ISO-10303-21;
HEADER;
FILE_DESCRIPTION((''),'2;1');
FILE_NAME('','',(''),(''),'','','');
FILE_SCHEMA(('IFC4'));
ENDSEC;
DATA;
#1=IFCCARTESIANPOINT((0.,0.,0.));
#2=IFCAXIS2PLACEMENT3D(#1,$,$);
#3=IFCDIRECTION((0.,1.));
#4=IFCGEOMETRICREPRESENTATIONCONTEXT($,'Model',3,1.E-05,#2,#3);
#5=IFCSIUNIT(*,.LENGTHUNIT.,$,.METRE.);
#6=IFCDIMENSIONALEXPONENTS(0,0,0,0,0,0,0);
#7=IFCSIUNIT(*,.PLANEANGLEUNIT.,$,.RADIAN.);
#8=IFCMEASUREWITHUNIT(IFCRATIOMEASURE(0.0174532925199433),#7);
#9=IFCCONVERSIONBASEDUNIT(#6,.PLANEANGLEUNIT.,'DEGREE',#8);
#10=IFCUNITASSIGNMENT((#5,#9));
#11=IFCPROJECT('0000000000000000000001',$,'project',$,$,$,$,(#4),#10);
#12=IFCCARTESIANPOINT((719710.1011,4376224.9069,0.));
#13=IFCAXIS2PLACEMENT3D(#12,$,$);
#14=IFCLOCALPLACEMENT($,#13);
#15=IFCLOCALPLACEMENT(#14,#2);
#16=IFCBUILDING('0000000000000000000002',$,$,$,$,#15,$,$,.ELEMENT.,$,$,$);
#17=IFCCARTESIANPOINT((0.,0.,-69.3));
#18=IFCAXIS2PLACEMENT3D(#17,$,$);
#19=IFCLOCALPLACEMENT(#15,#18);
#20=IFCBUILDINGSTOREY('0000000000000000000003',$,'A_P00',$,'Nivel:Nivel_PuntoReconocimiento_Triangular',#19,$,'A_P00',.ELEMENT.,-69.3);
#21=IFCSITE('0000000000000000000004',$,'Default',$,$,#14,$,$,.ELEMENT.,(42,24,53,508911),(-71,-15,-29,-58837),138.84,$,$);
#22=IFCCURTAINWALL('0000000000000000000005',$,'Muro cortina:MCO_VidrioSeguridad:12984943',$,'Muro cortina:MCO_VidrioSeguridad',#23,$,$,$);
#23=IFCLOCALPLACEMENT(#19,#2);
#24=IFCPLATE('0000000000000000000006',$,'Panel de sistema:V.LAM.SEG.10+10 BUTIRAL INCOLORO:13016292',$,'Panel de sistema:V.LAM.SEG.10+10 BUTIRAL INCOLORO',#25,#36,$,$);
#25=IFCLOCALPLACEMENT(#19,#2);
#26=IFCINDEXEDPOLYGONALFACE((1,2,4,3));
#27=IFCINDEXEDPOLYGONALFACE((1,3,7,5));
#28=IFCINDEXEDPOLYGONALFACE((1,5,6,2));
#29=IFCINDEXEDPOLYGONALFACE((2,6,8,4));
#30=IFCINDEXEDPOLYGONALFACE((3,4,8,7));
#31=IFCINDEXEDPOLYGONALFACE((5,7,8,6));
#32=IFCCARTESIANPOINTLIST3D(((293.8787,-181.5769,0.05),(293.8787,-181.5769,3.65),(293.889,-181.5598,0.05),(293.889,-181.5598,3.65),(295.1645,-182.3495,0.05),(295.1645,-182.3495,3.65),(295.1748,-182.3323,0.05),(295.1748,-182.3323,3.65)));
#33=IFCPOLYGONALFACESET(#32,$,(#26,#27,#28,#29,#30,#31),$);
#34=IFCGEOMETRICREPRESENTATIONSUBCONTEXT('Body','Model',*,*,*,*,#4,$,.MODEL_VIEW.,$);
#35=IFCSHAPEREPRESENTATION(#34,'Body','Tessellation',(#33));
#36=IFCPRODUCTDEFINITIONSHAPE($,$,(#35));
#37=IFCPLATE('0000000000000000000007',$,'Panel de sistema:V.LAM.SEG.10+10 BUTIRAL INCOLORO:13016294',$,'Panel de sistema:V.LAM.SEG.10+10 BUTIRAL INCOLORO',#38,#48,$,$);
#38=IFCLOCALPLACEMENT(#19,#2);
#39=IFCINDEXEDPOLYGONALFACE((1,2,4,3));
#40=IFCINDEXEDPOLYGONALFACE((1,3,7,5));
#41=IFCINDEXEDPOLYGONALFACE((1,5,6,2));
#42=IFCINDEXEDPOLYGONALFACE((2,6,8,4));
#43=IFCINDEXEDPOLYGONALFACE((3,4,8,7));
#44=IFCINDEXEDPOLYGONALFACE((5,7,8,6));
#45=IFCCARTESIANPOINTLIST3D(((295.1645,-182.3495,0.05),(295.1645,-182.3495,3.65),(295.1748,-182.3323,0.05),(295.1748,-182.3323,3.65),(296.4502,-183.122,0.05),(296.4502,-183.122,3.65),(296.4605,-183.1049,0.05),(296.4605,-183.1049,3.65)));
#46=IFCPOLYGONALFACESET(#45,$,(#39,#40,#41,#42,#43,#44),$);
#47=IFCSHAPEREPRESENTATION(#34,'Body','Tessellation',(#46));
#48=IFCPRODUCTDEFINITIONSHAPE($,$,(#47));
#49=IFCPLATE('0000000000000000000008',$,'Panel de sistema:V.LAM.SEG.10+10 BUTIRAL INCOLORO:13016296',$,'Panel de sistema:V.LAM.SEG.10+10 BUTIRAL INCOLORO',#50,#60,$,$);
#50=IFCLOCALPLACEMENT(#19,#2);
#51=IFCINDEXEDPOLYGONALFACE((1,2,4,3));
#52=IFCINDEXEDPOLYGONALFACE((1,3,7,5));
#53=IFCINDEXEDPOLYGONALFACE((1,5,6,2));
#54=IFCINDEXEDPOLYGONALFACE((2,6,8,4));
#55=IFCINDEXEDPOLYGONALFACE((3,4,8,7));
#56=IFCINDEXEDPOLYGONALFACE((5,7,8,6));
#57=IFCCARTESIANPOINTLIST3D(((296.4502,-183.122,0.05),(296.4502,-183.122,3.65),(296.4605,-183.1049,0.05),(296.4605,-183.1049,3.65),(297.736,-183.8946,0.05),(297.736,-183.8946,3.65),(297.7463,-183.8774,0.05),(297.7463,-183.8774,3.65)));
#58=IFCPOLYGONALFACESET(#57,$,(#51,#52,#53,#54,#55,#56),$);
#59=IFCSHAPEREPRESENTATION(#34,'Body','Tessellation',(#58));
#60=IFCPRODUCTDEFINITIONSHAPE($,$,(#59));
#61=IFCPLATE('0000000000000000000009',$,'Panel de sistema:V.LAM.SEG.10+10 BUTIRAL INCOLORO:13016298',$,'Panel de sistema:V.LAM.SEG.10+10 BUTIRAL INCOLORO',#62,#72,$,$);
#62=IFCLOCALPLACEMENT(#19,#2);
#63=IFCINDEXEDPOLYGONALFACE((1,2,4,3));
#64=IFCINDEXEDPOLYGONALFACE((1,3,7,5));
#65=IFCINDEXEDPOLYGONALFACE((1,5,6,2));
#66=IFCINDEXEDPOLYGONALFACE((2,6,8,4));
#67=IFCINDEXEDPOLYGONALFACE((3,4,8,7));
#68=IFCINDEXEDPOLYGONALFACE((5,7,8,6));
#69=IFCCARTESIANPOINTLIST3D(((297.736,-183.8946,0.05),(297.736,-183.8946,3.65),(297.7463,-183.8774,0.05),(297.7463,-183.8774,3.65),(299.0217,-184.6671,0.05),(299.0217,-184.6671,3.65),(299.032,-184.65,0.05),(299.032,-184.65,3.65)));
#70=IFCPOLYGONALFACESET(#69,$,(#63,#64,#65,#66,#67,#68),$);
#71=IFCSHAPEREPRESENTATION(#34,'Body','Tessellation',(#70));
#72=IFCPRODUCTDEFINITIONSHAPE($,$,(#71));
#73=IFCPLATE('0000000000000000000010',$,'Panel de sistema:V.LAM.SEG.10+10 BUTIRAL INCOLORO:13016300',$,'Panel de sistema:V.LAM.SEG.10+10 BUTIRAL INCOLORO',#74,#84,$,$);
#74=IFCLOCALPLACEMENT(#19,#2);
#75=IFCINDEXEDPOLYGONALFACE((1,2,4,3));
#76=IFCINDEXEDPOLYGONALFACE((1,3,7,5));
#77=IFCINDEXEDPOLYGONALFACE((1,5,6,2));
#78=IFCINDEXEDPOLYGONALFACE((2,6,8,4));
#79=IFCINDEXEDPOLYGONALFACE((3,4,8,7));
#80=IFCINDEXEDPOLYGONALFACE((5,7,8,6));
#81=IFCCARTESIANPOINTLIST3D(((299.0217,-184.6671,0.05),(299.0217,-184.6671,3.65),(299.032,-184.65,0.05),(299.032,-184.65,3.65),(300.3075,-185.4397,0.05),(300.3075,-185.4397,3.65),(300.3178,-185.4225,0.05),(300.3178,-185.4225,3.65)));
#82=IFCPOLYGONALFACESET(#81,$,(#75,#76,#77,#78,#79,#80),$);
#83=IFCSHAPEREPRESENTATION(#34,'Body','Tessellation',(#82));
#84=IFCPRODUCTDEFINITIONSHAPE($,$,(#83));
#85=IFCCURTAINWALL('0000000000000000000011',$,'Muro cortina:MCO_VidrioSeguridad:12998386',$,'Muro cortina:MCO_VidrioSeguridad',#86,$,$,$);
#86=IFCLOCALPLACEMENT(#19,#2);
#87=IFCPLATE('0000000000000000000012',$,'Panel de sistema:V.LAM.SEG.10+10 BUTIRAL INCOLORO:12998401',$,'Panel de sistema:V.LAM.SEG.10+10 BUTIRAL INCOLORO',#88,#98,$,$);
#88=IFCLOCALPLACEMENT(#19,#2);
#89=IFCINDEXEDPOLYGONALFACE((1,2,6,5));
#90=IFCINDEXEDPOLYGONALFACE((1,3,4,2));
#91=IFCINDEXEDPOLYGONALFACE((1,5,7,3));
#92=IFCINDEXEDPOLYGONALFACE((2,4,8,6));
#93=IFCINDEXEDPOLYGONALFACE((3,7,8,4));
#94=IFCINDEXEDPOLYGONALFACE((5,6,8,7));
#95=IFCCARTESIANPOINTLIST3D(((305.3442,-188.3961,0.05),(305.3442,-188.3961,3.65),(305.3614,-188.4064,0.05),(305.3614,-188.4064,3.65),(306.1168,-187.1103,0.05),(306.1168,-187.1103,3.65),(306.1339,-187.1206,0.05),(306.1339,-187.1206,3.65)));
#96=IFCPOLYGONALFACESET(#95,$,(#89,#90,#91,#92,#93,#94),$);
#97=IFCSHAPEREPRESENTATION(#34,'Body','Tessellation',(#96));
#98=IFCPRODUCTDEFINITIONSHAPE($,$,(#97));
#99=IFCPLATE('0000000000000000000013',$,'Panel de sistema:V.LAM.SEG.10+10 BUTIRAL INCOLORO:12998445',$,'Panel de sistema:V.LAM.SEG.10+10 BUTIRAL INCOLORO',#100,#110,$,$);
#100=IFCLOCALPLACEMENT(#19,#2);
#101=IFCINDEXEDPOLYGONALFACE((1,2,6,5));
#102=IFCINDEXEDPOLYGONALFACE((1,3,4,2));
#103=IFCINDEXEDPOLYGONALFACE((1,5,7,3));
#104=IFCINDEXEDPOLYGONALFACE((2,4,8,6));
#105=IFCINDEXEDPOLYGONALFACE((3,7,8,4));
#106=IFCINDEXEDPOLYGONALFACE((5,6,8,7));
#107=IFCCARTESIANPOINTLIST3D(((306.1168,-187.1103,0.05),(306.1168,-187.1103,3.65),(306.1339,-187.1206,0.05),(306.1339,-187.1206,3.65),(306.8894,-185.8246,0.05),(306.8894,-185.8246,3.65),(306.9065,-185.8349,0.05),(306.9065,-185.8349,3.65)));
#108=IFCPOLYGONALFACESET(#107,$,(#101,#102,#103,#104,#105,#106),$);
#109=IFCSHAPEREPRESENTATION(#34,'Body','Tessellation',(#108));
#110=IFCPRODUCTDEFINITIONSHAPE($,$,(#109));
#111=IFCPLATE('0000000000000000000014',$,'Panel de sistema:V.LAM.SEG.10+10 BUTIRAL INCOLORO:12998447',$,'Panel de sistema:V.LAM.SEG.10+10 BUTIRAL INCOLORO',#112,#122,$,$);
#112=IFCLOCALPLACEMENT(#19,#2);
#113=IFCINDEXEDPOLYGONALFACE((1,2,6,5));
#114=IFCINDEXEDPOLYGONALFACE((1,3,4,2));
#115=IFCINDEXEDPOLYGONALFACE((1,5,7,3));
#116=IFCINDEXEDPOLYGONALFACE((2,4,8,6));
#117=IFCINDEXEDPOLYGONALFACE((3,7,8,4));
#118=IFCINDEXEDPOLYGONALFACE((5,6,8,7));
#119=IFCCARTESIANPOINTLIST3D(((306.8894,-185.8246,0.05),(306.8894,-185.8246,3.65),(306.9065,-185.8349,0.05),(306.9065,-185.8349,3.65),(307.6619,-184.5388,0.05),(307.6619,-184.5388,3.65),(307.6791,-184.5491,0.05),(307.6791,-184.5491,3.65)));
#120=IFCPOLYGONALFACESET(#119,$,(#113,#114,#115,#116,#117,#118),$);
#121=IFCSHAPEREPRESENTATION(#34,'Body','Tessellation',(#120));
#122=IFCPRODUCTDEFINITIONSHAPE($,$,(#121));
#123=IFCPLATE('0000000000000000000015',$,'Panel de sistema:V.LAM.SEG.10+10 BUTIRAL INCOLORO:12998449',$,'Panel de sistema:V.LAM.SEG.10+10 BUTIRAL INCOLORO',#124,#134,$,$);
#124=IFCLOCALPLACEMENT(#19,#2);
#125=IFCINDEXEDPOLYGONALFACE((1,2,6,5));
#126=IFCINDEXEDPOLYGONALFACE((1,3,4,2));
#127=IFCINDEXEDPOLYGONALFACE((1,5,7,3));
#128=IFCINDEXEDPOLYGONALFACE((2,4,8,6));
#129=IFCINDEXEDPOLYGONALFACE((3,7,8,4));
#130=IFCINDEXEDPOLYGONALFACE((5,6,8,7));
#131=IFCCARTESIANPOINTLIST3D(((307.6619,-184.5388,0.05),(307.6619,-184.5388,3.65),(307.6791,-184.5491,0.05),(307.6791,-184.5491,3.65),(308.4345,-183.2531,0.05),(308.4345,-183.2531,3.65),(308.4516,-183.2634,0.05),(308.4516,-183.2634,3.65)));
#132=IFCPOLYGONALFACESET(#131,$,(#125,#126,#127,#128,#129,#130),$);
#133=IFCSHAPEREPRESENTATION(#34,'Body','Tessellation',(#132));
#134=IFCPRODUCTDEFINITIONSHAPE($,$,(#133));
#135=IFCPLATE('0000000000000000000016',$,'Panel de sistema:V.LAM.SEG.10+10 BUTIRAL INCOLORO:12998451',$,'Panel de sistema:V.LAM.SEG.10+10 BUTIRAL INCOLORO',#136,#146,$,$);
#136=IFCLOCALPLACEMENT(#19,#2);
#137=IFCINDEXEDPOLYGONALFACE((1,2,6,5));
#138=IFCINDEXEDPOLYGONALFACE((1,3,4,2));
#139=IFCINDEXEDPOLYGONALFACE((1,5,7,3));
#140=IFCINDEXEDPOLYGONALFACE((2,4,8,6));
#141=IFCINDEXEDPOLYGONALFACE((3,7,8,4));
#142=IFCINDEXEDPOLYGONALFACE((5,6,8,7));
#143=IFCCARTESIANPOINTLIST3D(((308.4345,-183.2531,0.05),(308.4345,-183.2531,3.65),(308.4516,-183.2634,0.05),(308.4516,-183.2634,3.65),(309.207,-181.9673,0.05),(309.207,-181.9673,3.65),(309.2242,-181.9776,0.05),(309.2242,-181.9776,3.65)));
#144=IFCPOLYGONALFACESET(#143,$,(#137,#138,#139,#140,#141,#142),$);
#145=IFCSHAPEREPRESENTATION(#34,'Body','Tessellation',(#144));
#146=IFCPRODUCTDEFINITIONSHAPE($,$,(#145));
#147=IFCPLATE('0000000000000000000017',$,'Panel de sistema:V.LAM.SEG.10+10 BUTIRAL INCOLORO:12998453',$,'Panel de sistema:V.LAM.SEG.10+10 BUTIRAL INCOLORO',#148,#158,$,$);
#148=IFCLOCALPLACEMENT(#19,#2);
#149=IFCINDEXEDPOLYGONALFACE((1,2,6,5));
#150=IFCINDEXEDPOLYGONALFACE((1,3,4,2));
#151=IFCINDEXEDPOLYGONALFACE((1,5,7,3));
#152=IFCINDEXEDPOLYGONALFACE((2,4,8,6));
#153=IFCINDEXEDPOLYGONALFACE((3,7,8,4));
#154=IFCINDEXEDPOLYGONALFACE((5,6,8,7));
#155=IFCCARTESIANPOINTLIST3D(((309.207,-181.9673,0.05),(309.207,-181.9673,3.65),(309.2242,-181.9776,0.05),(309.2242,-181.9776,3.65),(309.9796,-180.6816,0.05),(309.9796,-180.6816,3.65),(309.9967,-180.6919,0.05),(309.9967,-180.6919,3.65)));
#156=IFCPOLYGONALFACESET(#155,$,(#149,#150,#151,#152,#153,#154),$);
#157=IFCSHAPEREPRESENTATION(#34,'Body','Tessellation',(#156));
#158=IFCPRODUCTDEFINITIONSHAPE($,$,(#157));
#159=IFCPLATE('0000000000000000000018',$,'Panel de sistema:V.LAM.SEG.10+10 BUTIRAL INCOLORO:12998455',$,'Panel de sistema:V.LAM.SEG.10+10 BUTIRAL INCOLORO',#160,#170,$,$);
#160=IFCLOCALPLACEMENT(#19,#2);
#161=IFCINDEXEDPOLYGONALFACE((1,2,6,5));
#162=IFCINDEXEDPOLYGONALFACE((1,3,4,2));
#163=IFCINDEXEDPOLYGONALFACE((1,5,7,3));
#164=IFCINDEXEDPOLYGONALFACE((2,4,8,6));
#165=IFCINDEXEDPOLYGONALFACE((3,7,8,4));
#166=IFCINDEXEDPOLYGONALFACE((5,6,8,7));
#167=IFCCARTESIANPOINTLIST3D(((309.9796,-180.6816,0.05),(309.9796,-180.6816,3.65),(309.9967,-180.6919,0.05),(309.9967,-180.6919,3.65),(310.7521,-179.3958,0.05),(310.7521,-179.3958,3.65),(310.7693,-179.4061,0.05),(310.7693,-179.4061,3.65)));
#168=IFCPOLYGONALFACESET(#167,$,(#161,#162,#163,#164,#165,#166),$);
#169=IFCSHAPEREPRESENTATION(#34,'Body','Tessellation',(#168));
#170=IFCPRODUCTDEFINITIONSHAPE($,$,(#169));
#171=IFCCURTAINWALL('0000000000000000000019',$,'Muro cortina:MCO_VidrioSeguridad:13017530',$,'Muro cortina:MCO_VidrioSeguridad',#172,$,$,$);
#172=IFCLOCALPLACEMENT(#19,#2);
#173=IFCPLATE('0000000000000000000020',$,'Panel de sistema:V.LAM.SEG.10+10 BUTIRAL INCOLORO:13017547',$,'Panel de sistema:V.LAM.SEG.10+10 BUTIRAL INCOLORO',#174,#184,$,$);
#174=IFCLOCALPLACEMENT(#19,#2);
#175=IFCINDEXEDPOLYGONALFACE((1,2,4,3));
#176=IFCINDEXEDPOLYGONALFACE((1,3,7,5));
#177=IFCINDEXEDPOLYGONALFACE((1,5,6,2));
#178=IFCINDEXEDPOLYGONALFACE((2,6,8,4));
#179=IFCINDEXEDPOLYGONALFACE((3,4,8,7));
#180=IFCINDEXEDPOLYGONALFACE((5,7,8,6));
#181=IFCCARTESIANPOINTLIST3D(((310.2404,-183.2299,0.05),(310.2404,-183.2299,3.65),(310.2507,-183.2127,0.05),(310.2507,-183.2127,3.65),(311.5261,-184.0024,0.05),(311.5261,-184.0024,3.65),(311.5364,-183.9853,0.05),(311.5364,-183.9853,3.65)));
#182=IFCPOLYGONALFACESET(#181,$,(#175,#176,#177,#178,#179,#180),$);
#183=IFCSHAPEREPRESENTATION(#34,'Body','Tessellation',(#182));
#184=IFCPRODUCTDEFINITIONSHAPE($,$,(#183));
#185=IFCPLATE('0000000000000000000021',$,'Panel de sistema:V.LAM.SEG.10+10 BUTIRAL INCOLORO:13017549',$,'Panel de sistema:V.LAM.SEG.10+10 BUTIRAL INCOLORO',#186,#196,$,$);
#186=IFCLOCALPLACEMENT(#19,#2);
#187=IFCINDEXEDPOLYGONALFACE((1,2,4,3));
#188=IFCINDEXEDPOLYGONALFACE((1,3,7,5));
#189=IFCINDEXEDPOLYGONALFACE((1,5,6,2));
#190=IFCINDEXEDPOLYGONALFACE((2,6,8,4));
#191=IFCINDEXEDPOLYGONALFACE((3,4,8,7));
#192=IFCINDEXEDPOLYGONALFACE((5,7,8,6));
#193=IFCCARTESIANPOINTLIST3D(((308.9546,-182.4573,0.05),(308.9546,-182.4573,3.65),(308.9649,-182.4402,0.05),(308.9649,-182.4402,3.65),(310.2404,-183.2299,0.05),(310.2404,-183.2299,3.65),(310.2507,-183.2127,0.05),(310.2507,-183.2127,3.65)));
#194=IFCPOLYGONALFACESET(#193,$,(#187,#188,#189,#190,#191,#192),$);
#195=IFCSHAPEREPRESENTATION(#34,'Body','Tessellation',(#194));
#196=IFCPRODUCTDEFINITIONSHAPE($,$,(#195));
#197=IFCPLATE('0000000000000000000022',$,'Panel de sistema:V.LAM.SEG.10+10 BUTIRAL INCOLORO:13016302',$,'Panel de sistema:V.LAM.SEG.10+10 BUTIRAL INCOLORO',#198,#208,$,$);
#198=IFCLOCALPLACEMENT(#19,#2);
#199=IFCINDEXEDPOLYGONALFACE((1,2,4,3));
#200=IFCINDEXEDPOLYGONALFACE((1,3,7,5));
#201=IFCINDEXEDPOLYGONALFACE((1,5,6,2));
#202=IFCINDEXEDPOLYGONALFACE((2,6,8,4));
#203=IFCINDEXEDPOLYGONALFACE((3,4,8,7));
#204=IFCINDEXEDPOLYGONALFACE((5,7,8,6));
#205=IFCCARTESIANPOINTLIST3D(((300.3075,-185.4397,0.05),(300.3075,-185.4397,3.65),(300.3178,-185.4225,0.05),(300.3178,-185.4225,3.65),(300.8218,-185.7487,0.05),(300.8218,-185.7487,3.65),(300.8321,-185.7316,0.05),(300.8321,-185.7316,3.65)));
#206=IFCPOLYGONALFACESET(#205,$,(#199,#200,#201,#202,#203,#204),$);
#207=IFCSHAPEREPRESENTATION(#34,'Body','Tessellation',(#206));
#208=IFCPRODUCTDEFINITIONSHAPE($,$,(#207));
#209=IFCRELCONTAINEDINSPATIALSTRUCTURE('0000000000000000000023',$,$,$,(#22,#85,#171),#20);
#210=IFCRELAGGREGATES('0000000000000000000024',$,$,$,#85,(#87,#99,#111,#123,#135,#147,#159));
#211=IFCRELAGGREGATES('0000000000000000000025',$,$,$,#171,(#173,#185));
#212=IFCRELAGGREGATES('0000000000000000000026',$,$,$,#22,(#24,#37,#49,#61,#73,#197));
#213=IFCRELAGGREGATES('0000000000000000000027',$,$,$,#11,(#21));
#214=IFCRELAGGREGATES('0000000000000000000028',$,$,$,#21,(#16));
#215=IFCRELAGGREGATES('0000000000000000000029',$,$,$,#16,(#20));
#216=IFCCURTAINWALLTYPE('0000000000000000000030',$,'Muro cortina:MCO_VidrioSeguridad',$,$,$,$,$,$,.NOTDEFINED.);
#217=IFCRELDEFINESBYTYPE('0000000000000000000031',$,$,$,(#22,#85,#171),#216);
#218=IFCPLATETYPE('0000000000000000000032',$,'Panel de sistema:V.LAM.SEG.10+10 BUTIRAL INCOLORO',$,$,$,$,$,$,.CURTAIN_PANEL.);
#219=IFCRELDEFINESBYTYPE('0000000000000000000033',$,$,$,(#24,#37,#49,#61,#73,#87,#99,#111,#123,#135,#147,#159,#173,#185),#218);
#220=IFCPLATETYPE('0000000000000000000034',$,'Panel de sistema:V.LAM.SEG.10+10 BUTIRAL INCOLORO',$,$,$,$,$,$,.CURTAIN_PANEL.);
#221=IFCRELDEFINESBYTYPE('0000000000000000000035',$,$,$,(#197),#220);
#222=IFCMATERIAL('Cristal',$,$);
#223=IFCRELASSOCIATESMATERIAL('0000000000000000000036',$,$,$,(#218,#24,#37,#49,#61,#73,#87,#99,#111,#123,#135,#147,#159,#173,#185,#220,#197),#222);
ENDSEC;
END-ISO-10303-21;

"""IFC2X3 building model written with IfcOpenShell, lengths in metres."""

from ifc_helpers import new_model, entity, si_unit, converted_unit, direction, frame, origin, origin_2d_with_axis, place, context, subcontext, project, spatial, rectangle, extrude, source, transform, mapped, material, type_object, type_shapes, element, aggregate, save


model = new_model("IFC2X3")

# Units and contexts
model_context = context("Model", 3, precision=1e-05, world=origin(), true_north=direction((0.0, 1.0)))
body_context = subcontext(model_context, "Body", "Model", "MODEL_VIEW")
ifc_project = project(units=[si_unit("LENGTHUNIT", "METRE"), converted_unit("PLANEANGLEUNIT", "DEGREE", entity("IfcRatioMeasure", 0.0174532925199433), si_unit("PLANEANGLEUNIT", "RADIAN"), dimensions=[0, 0, 0, 0, 0, 0, 0])], contexts=[model_context])

# Site, building, storey
site_placement = place(None, frame((719710.1011, 4376224.9069, 0.0)))
site = spatial("IfcSite", under=ifc_project, at=site_placement, Name="Default", CompositionType="ELEMENT", RefLatitude=(42, 24, 53, 508911), RefLongitude=(-71, -15, -29, -58837), RefElevation=138.84)
building_placement = place(site_placement, origin())
building = spatial("IfcBuilding", under=site, at=building_placement, CompositionType="ELEMENT")
storey_placement = place(building_placement, frame((0.0, 0.0, -69.3)))
storey = spatial("IfcBuildingStorey", under=building, at=storey_placement, Name="A_P00", ObjectType="Nivel:Nivel_PuntoReconocimiento_Triangular", LongName="A_P00", CompositionType="ELEMENT", Elevation=-69.3)

# Curtain walls, plates
curtain_wall_type = type_object("IfcCurtainWallType", Name="Muro cortina:MCO_VidrioSeguridad", PredefinedType="NOTDEFINED")
curtain_wall_1_placement = place(storey_placement, frame((0.0, 0.0, 69.3)))
curtain_wall_1 = element("IfcCurtainWall", 1, at=curtain_wall_1_placement, inside=storey, type_object=curtain_wall_type, Name="Muro cortina:MCO_VidrioSeguridad:12984943", ObjectType="Muro cortina:MCO_VidrioSeguridad")
ifc_material_1 = material(Name="Cristal")
plate_type_1 = type_object("IfcPlateType", Name="Panel de sistema:V.LAM.SEG.10+10 BUTIRAL INCOLORO", PredefinedType="CURTAIN_PANEL", material=ifc_material_1)
shared_shape_1 = source(origin(), body_context, "Body", "SweptSolid", [
    extrude(rectangle(XDim=0.02, YDim=1.5, at=origin_2d_with_axis()), frame((0.0, 0.0, 0.0), z_axis=(0.0, 0.0, 1.0), x_axis=(0.0, 1.0, 0.0)), (0.0, 0.0, 1.0), 3.6),
])
type_shapes(plate_type_1, [shared_shape_1])
plate_1_placement = place(curtain_wall_1_placement, frame((294.5267, -181.9546, -69.25), z_axis=(0.0, 0.0, 1.0), x_axis=(0.857167, -0.515038, 0.0)))
plate_1 = element("IfcPlate", 2, at=plate_1_placement, type_object=plate_type_1, material=ifc_material_1, Name="Panel de sistema:V.LAM.SEG.10+10 BUTIRAL INCOLORO:13016292", ObjectType="Panel de sistema:V.LAM.SEG.10+10 BUTIRAL INCOLORO", context=body_context, shape_type="MappedRepresentation", body=[
    mapped(shared_shape_1, transform((0.0, 0.0, 0.0), scale=1.0)),
])
plate_2_placement = place(curtain_wall_1_placement, frame((295.8125, -182.7272, -69.25), z_axis=(0.0, 0.0, 1.0), x_axis=(0.857167, -0.515038, 0.0)))
plate_2 = element("IfcPlate", 3, at=plate_2_placement, type_object=plate_type_1, material=ifc_material_1, Name="Panel de sistema:V.LAM.SEG.10+10 BUTIRAL INCOLORO:13016294", ObjectType="Panel de sistema:V.LAM.SEG.10+10 BUTIRAL INCOLORO", context=body_context, shape_type="MappedRepresentation", body=[
    mapped(shared_shape_1, transform((0.0, 0.0, 0.0), scale=1.0)),
])
plate_3_placement = place(curtain_wall_1_placement, frame((297.0983, -183.4997, -69.25), z_axis=(0.0, 0.0, 1.0), x_axis=(0.857167, -0.515038, 0.0)))
plate_3 = element("IfcPlate", 4, at=plate_3_placement, type_object=plate_type_1, material=ifc_material_1, Name="Panel de sistema:V.LAM.SEG.10+10 BUTIRAL INCOLORO:13016296", ObjectType="Panel de sistema:V.LAM.SEG.10+10 BUTIRAL INCOLORO", context=body_context, shape_type="MappedRepresentation", body=[
    mapped(shared_shape_1, transform((0.0, 0.0, 0.0), scale=1.0)),
])
plate_4_placement = place(curtain_wall_1_placement, frame((298.384, -184.2723, -69.25), z_axis=(0.0, 0.0, 1.0), x_axis=(0.857167, -0.515038, 0.0)))
plate_4 = element("IfcPlate", 5, at=plate_4_placement, type_object=plate_type_1, material=ifc_material_1, Name="Panel de sistema:V.LAM.SEG.10+10 BUTIRAL INCOLORO:13016298", ObjectType="Panel de sistema:V.LAM.SEG.10+10 BUTIRAL INCOLORO", context=body_context, shape_type="MappedRepresentation", body=[
    mapped(shared_shape_1, transform((0.0, 0.0, 0.0), scale=1.0)),
])
plate_5_placement = place(curtain_wall_1_placement, frame((299.6698, -185.0448, -69.25), z_axis=(0.0, 0.0, 1.0), x_axis=(0.857167, -0.515038, 0.0)))
plate_5 = element("IfcPlate", 6, at=plate_5_placement, type_object=plate_type_1, material=ifc_material_1, Name="Panel de sistema:V.LAM.SEG.10+10 BUTIRAL INCOLORO:13016300", ObjectType="Panel de sistema:V.LAM.SEG.10+10 BUTIRAL INCOLORO", context=body_context, shape_type="MappedRepresentation", body=[
    mapped(shared_shape_1, transform((0.0, 0.0, 0.0), scale=1.0)),
])
curtain_wall_2_placement = place(storey_placement, frame((0.0, 0.0, 69.3)))
curtain_wall_2 = element("IfcCurtainWall", 7, at=curtain_wall_2_placement, inside=storey, type_object=curtain_wall_type, Name="Muro cortina:MCO_VidrioSeguridad:12998386", ObjectType="Muro cortina:MCO_VidrioSeguridad")
plate_6_placement = place(curtain_wall_2_placement, frame((305.7391, -187.7584, -69.25), z_axis=(0.0, 0.0, 1.0), x_axis=(0.515038, 0.857167, 0.0)))
plate_6 = element("IfcPlate", 8, at=plate_6_placement, type_object=plate_type_1, material=ifc_material_1, Name="Panel de sistema:V.LAM.SEG.10+10 BUTIRAL INCOLORO:12998401", ObjectType="Panel de sistema:V.LAM.SEG.10+10 BUTIRAL INCOLORO", context=body_context, shape_type="MappedRepresentation", body=[
    mapped(shared_shape_1, transform((0.0, 0.0, 0.0), scale=1.0)),
])
plate_7_placement = place(curtain_wall_2_placement, frame((306.5116, -186.4726, -69.25), z_axis=(0.0, 0.0, 1.0), x_axis=(0.515038, 0.857167, 0.0)))
plate_7 = element("IfcPlate", 9, at=plate_7_placement, type_object=plate_type_1, material=ifc_material_1, Name="Panel de sistema:V.LAM.SEG.10+10 BUTIRAL INCOLORO:12998445", ObjectType="Panel de sistema:V.LAM.SEG.10+10 BUTIRAL INCOLORO", context=body_context, shape_type="MappedRepresentation", body=[
    mapped(shared_shape_1, transform((0.0, 0.0, 0.0), scale=1.0)),
])
plate_8_placement = place(curtain_wall_2_placement, frame((307.2842, -185.1869, -69.25), z_axis=(0.0, 0.0, 1.0), x_axis=(0.515038, 0.857167, 0.0)))
plate_8 = element("IfcPlate", 10, at=plate_8_placement, type_object=plate_type_1, material=ifc_material_1, Name="Panel de sistema:V.LAM.SEG.10+10 BUTIRAL INCOLORO:12998447", ObjectType="Panel de sistema:V.LAM.SEG.10+10 BUTIRAL INCOLORO", context=body_context, shape_type="MappedRepresentation", body=[
    mapped(shared_shape_1, transform((0.0, 0.0, 0.0), scale=1.0)),
])
plate_9_placement = place(curtain_wall_2_placement, frame((308.0568, -183.9011, -69.25), z_axis=(0.0, 0.0, 1.0), x_axis=(0.515038, 0.857167, 0.0)))
plate_9 = element("IfcPlate", 11, at=plate_9_placement, type_object=plate_type_1, material=ifc_material_1, Name="Panel de sistema:V.LAM.SEG.10+10 BUTIRAL INCOLORO:12998449", ObjectType="Panel de sistema:V.LAM.SEG.10+10 BUTIRAL INCOLORO", context=body_context, shape_type="MappedRepresentation", body=[
    mapped(shared_shape_1, transform((0.0, 0.0, 0.0), scale=1.0)),
])
plate_10_placement = place(curtain_wall_2_placement, frame((308.8293, -182.6153, -69.25), z_axis=(0.0, 0.0, 1.0), x_axis=(0.515038, 0.857167, 0.0)))
plate_10 = element("IfcPlate", 12, at=plate_10_placement, type_object=plate_type_1, material=ifc_material_1, Name="Panel de sistema:V.LAM.SEG.10+10 BUTIRAL INCOLORO:12998451", ObjectType="Panel de sistema:V.LAM.SEG.10+10 BUTIRAL INCOLORO", context=body_context, shape_type="MappedRepresentation", body=[
    mapped(shared_shape_1, transform((0.0, 0.0, 0.0), scale=1.0)),
])
plate_11_placement = place(curtain_wall_2_placement, frame((309.6019, -181.3296, -69.25), z_axis=(0.0, 0.0, 1.0), x_axis=(0.515038, 0.857167, 0.0)))
plate_11 = element("IfcPlate", 13, at=plate_11_placement, type_object=plate_type_1, material=ifc_material_1, Name="Panel de sistema:V.LAM.SEG.10+10 BUTIRAL INCOLORO:12998453", ObjectType="Panel de sistema:V.LAM.SEG.10+10 BUTIRAL INCOLORO", context=body_context, shape_type="MappedRepresentation", body=[
    mapped(shared_shape_1, transform((0.0, 0.0, 0.0), scale=1.0)),
])
plate_12_placement = place(curtain_wall_2_placement, frame((310.3744, -180.0438, -69.25), z_axis=(0.0, 0.0, 1.0), x_axis=(0.515038, 0.857167, 0.0)))
plate_12 = element("IfcPlate", 14, at=plate_12_placement, type_object=plate_type_1, material=ifc_material_1, Name="Panel de sistema:V.LAM.SEG.10+10 BUTIRAL INCOLORO:12998455", ObjectType="Panel de sistema:V.LAM.SEG.10+10 BUTIRAL INCOLORO", context=body_context, shape_type="MappedRepresentation", body=[
    mapped(shared_shape_1, transform((0.0, 0.0, 0.0), scale=1.0)),
])
aggregate(curtain_wall_2, [plate_6, plate_7, plate_8, plate_9, plate_10, plate_11, plate_12])
curtain_wall_3_placement = place(storey_placement, frame((0.0, 0.0, 69.3)))
curtain_wall_3 = element("IfcCurtainWall", 15, at=curtain_wall_3_placement, inside=storey, type_object=curtain_wall_type, Name="Muro cortina:MCO_VidrioSeguridad:13017530", ObjectType="Muro cortina:MCO_VidrioSeguridad")
plate_13_placement = place(curtain_wall_3_placement, frame((310.8884, -183.6076, -69.25), z_axis=(0.0, 0.0, 1.0), x_axis=(-0.857167, 0.515038, 0.0)))
plate_13 = element("IfcPlate", 16, at=plate_13_placement, type_object=plate_type_1, material=ifc_material_1, Name="Panel de sistema:V.LAM.SEG.10+10 BUTIRAL INCOLORO:13017547", ObjectType="Panel de sistema:V.LAM.SEG.10+10 BUTIRAL INCOLORO", context=body_context, shape_type="MappedRepresentation", body=[
    mapped(shared_shape_1, transform((0.0, 0.0, 0.0), scale=1.0)),
])
plate_14_placement = place(curtain_wall_3_placement, frame((309.6026, -182.835, -69.25), z_axis=(0.0, 0.0, 1.0), x_axis=(-0.857167, 0.515038, 0.0)))
plate_14 = element("IfcPlate", 17, at=plate_14_placement, type_object=plate_type_1, material=ifc_material_1, Name="Panel de sistema:V.LAM.SEG.10+10 BUTIRAL INCOLORO:13017549", ObjectType="Panel de sistema:V.LAM.SEG.10+10 BUTIRAL INCOLORO", context=body_context, shape_type="MappedRepresentation", body=[
    mapped(shared_shape_1, transform((0.0, 0.0, 0.0), scale=1.0)),
])
aggregate(curtain_wall_3, [plate_13, plate_14])

# Plate
plate_type_2 = type_object("IfcPlateType", Name="Panel de sistema:V.LAM.SEG.10+10 BUTIRAL INCOLORO", PredefinedType="CURTAIN_PANEL", material=ifc_material_1)
shared_shape_2 = source(origin(), body_context, "Body", "SweptSolid", [
    extrude(rectangle(XDim=0.02, YDim=0.6, at=origin_2d_with_axis()), frame((0.0, 0.0, 0.0), z_axis=(0.0, 0.0, 1.0), x_axis=(0.0, 1.0, 0.0)), (0.0, 0.0, 1.0), 3.6),
])
type_shapes(plate_type_2, [shared_shape_2])
plate_15_placement = place(curtain_wall_1_placement, frame((300.5698, -185.5856, -69.25), z_axis=(0.0, 0.0, 1.0), x_axis=(0.857167, -0.515038, 0.0)))
plate_15 = element("IfcPlate", 18, at=plate_15_placement, type_object=plate_type_2, material=ifc_material_1, Name="Panel de sistema:V.LAM.SEG.10+10 BUTIRAL INCOLORO:13016302", ObjectType="Panel de sistema:V.LAM.SEG.10+10 BUTIRAL INCOLORO", context=body_context, shape_type="MappedRepresentation", body=[
    mapped(shared_shape_2, transform((0.0, 0.0, 0.0), scale=1.0)),
])
aggregate(curtain_wall_1, [plate_1, plate_2, plate_3, plate_4, plate_5, plate_15])

save(model, "model.ifc")
